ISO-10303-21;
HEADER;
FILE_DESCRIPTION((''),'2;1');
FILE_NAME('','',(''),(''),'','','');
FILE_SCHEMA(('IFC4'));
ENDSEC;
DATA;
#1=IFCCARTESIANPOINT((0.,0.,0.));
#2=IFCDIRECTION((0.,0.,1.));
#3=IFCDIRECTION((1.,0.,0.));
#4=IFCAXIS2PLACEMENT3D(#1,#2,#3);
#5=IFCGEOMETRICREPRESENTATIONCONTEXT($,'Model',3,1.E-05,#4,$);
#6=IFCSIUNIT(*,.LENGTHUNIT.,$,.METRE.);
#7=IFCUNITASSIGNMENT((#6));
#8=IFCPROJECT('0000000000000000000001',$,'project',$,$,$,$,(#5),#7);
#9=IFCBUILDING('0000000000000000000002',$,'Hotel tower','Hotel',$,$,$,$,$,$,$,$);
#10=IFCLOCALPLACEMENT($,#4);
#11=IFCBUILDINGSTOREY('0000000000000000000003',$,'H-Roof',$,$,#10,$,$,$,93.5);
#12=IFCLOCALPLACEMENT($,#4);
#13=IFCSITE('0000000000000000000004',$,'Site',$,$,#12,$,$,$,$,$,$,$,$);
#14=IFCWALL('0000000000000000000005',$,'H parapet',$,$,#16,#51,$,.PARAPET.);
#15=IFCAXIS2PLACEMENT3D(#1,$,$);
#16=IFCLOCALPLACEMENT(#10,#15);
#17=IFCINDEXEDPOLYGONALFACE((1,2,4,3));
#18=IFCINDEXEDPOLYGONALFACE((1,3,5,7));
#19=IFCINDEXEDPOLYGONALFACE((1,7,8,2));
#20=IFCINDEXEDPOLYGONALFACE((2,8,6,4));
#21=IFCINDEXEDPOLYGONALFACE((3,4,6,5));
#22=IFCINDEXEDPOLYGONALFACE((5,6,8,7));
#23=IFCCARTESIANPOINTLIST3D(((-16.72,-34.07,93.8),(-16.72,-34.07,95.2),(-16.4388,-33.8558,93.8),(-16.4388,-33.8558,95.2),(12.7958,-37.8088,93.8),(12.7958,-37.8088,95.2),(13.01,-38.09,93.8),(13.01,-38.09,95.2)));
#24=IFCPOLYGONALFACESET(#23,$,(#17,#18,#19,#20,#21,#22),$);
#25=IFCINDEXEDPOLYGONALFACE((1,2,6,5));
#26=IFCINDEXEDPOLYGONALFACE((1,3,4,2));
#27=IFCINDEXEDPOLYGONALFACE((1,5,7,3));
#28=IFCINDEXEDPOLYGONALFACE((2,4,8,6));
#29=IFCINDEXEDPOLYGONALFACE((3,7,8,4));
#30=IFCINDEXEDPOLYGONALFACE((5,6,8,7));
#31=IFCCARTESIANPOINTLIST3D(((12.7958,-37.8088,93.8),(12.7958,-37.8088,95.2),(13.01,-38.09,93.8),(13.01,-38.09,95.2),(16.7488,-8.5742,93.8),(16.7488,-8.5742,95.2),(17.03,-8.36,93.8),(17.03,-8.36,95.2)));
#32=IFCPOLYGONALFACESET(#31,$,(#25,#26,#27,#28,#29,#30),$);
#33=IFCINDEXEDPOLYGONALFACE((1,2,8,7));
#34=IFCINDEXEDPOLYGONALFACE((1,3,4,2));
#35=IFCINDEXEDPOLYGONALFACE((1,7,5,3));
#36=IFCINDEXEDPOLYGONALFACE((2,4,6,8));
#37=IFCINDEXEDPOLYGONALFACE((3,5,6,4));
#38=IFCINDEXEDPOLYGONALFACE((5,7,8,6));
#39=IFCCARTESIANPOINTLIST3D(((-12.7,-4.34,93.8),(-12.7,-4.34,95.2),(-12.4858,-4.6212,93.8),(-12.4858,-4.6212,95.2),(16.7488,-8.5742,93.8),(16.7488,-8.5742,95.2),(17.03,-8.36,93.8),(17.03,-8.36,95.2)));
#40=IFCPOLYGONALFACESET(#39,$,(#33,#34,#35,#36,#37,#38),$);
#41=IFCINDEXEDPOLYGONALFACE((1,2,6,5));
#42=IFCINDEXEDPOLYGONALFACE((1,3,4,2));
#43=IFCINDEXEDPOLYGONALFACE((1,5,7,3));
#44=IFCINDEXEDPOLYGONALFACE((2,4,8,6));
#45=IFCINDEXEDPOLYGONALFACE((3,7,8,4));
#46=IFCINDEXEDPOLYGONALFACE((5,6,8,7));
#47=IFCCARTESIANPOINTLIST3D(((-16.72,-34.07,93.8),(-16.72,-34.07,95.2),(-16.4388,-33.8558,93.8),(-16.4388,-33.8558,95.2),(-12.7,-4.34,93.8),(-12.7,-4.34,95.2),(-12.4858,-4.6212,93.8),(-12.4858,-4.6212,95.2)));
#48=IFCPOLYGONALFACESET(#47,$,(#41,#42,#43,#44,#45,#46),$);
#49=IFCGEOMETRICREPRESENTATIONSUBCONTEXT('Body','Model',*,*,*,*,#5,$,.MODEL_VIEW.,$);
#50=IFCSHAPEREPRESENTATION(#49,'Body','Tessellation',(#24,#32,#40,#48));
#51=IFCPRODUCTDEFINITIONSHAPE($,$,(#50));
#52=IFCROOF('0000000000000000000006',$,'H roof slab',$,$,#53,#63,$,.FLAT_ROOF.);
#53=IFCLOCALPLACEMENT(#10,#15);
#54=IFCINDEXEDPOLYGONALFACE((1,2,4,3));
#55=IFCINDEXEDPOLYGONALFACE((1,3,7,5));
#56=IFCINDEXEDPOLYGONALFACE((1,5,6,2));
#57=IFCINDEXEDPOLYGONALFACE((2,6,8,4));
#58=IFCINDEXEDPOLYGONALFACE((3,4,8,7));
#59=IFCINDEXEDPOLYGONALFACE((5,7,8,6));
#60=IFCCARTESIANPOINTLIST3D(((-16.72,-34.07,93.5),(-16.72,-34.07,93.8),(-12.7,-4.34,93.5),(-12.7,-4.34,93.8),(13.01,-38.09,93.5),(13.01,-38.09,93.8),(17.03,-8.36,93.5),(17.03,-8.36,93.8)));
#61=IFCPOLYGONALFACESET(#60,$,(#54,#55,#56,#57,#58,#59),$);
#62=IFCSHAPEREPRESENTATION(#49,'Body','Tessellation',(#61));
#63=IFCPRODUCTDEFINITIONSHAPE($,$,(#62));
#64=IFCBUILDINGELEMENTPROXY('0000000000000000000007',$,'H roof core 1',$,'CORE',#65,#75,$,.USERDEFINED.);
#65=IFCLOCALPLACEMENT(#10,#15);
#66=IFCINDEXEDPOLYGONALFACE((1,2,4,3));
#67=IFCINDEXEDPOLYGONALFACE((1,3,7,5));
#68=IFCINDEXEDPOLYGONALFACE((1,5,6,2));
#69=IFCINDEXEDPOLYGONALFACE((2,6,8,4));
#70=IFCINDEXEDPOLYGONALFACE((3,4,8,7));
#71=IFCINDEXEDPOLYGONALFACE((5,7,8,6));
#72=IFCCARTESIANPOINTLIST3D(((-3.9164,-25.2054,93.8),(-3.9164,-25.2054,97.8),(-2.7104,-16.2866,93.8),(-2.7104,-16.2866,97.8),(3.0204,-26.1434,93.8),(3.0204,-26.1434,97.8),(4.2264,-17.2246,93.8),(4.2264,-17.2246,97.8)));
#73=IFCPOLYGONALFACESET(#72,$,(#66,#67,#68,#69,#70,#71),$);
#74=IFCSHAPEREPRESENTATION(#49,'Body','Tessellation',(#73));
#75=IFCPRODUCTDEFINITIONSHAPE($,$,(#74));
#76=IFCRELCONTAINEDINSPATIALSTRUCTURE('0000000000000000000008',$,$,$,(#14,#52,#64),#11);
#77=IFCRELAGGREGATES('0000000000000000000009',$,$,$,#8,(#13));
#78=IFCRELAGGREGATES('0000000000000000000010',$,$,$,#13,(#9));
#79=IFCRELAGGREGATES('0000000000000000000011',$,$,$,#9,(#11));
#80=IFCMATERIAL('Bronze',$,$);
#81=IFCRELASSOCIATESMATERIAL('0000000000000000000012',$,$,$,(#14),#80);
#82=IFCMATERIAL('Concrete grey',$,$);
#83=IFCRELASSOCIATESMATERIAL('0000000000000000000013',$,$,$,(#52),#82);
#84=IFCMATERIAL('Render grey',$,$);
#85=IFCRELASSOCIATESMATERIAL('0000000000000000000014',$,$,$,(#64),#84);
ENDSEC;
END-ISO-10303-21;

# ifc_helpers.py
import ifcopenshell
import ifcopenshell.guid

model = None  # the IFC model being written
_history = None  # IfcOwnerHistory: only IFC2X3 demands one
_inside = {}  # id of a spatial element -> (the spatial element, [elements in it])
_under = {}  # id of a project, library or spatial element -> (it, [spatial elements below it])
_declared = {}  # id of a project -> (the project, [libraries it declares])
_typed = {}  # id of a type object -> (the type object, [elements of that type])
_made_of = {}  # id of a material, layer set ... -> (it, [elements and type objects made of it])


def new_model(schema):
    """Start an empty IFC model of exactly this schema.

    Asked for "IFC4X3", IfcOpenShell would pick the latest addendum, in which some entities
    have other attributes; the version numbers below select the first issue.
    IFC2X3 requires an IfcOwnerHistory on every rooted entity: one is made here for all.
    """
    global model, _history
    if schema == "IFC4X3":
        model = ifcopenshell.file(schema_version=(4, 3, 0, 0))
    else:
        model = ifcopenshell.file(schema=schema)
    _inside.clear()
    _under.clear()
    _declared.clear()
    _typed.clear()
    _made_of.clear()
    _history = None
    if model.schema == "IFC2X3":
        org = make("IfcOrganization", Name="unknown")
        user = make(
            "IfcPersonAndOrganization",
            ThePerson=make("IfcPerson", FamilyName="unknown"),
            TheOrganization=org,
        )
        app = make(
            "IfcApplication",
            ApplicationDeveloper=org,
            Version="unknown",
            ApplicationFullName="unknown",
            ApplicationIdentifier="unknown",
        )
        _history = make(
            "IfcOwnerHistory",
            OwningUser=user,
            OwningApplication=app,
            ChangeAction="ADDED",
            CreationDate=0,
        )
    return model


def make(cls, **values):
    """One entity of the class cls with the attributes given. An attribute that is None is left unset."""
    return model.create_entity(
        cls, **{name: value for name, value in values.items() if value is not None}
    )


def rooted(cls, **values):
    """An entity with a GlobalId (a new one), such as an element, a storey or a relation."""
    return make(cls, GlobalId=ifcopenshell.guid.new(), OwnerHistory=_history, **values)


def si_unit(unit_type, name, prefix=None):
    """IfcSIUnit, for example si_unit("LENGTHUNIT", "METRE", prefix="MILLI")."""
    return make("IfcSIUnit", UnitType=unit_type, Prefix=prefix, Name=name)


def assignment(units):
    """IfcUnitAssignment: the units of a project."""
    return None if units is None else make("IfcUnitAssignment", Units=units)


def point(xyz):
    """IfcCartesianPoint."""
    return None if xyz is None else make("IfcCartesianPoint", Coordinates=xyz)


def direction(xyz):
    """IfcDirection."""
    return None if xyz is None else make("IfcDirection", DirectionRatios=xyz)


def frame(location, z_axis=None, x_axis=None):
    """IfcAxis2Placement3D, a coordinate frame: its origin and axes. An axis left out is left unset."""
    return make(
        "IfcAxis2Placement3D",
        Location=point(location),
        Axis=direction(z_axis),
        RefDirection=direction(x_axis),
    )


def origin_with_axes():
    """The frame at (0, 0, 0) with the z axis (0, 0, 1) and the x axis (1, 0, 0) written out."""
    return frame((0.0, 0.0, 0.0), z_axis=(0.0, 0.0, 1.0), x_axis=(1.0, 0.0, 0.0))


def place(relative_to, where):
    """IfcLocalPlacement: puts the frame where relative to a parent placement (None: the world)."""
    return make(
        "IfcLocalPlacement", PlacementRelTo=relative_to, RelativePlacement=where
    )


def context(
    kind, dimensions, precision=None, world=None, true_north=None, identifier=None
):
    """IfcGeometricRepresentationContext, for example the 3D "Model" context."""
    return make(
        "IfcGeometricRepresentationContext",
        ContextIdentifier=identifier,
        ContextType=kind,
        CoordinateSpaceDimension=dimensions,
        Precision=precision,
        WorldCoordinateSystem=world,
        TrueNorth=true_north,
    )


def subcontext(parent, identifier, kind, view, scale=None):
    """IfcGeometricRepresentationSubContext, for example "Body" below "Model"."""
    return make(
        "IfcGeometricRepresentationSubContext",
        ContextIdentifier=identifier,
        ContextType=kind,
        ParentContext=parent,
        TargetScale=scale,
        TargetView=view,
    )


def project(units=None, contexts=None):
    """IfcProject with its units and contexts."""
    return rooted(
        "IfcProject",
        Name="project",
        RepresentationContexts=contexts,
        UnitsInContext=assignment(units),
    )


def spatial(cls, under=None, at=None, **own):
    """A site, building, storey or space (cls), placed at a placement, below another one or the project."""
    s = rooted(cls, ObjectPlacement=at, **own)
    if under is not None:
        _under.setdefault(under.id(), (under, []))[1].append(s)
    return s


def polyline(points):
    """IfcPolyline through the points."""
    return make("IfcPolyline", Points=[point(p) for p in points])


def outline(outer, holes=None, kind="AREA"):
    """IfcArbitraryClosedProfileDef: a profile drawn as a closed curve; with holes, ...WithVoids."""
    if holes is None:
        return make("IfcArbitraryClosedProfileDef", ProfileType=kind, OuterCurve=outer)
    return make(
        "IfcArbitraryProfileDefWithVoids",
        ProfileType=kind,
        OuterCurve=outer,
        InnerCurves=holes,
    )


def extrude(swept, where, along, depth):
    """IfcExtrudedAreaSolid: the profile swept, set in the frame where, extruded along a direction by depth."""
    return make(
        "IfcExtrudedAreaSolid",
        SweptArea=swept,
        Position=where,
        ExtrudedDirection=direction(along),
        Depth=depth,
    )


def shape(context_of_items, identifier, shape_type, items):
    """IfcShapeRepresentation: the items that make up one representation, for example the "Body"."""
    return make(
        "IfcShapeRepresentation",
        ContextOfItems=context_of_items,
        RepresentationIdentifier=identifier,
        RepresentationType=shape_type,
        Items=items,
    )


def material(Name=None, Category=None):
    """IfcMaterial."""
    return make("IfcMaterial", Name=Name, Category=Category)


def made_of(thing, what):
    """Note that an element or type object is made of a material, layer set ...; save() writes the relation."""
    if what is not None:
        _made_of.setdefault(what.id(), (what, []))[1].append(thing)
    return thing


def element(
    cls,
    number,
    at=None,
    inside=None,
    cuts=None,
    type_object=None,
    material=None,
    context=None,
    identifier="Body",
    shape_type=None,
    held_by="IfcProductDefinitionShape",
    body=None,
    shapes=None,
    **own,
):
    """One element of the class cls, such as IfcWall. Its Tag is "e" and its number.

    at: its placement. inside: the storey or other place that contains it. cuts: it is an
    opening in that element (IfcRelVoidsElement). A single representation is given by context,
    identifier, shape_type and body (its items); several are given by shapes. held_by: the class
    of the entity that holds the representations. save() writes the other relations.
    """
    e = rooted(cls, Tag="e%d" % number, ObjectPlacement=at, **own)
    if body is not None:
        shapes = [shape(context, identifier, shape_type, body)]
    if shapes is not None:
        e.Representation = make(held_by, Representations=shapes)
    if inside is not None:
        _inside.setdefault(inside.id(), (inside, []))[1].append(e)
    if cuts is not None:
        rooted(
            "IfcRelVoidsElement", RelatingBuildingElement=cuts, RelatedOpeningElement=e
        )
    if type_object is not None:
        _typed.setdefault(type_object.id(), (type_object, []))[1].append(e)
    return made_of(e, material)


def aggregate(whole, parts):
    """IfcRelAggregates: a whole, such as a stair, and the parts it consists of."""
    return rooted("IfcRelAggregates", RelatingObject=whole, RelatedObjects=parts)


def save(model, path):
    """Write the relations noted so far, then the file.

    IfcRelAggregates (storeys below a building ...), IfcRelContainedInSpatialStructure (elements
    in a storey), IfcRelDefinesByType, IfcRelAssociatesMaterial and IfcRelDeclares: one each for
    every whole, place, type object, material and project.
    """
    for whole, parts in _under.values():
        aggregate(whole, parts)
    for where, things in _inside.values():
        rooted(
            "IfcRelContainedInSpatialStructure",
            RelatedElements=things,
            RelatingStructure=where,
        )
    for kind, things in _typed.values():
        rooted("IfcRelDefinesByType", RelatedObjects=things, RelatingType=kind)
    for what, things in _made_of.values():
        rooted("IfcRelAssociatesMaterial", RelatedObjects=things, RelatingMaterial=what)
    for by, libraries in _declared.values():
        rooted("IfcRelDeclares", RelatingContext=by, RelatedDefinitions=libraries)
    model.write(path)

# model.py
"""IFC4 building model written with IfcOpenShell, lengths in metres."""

from ifc_helpers import new_model, si_unit, frame, origin_with_axes, place, context, subcontext, project, spatial, polyline, outline, extrude, material, element, save


model = new_model("IFC4")

# Units and contexts
model_context = context("Model", 3, precision=1e-05, world=origin_with_axes())
body_context = subcontext(model_context, "Body", "Model", "MODEL_VIEW")
ifc_project = project(units=[si_unit("LENGTHUNIT", "METRE")], contexts=[model_context])

# Site, building, storey
site_placement = place(None, origin_with_axes())
site = spatial("IfcSite", under=ifc_project, at=site_placement, Name="Site")
building = spatial("IfcBuilding", under=site, Name="Hotel tower", Description="Hotel")
storey_placement = place(None, origin_with_axes())
storey = spatial("IfcBuildingStorey", under=building, at=storey_placement, Name="H-Roof", Elevation=93.5)

# Wall
ifc_material_1 = material(Name="Bronze")
wall_placement = place(storey_placement, origin_with_axes())
element("IfcWall", 1, at=wall_placement, inside=storey, material=ifc_material_1, Name="H parapet", PredefinedType="PARAPET", context=body_context, shape_type="SweptSolid", body=[
    extrude(outline(polyline([(-16.72, -34.07), (13.01, -38.09), (12.7958, -37.8088), (-16.4388, -33.8558), (-16.72, -34.07)])), frame((0.0, 0.0, 93.8), z_axis=(0.0, 0.0, 1.0), x_axis=(1.0, 0.0, 0.0)), (0.0, 0.0, 1.0), 1.4),
    extrude(outline(polyline([(13.01, -38.09), (17.03, -8.36), (16.7488, -8.5742), (12.7958, -37.8088), (13.01, -38.09)])), frame((0.0, 0.0, 93.8), z_axis=(0.0, 0.0, 1.0), x_axis=(1.0, 0.0, 0.0)), (0.0, 0.0, 1.0), 1.4),
    extrude(outline(polyline([(17.03, -8.36), (-12.7, -4.34), (-12.4858, -4.6212), (16.7488, -8.5742), (17.03, -8.36)])), frame((0.0, 0.0, 93.8), z_axis=(0.0, 0.0, 1.0), x_axis=(1.0, 0.0, 0.0)), (0.0, 0.0, 1.0), 1.4),
    extrude(outline(polyline([(-12.7, -4.34), (-16.72, -34.07), (-16.4388, -33.8558), (-12.4858, -4.6212), (-12.7, -4.34)])), frame((0.0, 0.0, 93.8), z_axis=(0.0, 0.0, 1.0), x_axis=(1.0, 0.0, 0.0)), (0.0, 0.0, 1.0), 1.4),
])

# Roof
ifc_material_2 = material(Name="Concrete grey")
roof_placement = place(storey_placement, origin_with_axes())
element("IfcRoof", 2, at=roof_placement, inside=storey, material=ifc_material_2, Name="H roof slab", PredefinedType="FLAT_ROOF", context=body_context, shape_type="SweptSolid", body=[
    extrude(outline(polyline([(-16.72, -34.07), (13.01, -38.09), (17.03, -8.36), (-12.7, -4.34), (-16.72, -34.07)])), frame((0.0, 0.0, 93.5), z_axis=(0.0, 0.0, 1.0), x_axis=(1.0, 0.0, 0.0)), (0.0, 0.0, 1.0), 0.3),
])

# Building element proxy
ifc_material_3 = material(Name="Render grey")
proxy_placement = place(storey_placement, origin_with_axes())
element("IfcBuildingElementProxy", 3, at=proxy_placement, inside=storey, material=ifc_material_3, Name="H roof core 1", ObjectType="CORE", PredefinedType="USERDEFINED", context=body_context, shape_type="SweptSolid", body=[
    extrude(outline(polyline([(3.0204, -26.1434), (4.2264, -17.2246), (-2.7104, -16.2866), (-3.9164, -25.2054), (3.0204, -26.1434)])), frame((0.0, 0.0, 93.8), z_axis=(0.0, 0.0, 1.0), x_axis=(1.0, 0.0, 0.0)), (0.0, 0.0, 1.0), 4.0),
])

save(model, "model.ifc")
